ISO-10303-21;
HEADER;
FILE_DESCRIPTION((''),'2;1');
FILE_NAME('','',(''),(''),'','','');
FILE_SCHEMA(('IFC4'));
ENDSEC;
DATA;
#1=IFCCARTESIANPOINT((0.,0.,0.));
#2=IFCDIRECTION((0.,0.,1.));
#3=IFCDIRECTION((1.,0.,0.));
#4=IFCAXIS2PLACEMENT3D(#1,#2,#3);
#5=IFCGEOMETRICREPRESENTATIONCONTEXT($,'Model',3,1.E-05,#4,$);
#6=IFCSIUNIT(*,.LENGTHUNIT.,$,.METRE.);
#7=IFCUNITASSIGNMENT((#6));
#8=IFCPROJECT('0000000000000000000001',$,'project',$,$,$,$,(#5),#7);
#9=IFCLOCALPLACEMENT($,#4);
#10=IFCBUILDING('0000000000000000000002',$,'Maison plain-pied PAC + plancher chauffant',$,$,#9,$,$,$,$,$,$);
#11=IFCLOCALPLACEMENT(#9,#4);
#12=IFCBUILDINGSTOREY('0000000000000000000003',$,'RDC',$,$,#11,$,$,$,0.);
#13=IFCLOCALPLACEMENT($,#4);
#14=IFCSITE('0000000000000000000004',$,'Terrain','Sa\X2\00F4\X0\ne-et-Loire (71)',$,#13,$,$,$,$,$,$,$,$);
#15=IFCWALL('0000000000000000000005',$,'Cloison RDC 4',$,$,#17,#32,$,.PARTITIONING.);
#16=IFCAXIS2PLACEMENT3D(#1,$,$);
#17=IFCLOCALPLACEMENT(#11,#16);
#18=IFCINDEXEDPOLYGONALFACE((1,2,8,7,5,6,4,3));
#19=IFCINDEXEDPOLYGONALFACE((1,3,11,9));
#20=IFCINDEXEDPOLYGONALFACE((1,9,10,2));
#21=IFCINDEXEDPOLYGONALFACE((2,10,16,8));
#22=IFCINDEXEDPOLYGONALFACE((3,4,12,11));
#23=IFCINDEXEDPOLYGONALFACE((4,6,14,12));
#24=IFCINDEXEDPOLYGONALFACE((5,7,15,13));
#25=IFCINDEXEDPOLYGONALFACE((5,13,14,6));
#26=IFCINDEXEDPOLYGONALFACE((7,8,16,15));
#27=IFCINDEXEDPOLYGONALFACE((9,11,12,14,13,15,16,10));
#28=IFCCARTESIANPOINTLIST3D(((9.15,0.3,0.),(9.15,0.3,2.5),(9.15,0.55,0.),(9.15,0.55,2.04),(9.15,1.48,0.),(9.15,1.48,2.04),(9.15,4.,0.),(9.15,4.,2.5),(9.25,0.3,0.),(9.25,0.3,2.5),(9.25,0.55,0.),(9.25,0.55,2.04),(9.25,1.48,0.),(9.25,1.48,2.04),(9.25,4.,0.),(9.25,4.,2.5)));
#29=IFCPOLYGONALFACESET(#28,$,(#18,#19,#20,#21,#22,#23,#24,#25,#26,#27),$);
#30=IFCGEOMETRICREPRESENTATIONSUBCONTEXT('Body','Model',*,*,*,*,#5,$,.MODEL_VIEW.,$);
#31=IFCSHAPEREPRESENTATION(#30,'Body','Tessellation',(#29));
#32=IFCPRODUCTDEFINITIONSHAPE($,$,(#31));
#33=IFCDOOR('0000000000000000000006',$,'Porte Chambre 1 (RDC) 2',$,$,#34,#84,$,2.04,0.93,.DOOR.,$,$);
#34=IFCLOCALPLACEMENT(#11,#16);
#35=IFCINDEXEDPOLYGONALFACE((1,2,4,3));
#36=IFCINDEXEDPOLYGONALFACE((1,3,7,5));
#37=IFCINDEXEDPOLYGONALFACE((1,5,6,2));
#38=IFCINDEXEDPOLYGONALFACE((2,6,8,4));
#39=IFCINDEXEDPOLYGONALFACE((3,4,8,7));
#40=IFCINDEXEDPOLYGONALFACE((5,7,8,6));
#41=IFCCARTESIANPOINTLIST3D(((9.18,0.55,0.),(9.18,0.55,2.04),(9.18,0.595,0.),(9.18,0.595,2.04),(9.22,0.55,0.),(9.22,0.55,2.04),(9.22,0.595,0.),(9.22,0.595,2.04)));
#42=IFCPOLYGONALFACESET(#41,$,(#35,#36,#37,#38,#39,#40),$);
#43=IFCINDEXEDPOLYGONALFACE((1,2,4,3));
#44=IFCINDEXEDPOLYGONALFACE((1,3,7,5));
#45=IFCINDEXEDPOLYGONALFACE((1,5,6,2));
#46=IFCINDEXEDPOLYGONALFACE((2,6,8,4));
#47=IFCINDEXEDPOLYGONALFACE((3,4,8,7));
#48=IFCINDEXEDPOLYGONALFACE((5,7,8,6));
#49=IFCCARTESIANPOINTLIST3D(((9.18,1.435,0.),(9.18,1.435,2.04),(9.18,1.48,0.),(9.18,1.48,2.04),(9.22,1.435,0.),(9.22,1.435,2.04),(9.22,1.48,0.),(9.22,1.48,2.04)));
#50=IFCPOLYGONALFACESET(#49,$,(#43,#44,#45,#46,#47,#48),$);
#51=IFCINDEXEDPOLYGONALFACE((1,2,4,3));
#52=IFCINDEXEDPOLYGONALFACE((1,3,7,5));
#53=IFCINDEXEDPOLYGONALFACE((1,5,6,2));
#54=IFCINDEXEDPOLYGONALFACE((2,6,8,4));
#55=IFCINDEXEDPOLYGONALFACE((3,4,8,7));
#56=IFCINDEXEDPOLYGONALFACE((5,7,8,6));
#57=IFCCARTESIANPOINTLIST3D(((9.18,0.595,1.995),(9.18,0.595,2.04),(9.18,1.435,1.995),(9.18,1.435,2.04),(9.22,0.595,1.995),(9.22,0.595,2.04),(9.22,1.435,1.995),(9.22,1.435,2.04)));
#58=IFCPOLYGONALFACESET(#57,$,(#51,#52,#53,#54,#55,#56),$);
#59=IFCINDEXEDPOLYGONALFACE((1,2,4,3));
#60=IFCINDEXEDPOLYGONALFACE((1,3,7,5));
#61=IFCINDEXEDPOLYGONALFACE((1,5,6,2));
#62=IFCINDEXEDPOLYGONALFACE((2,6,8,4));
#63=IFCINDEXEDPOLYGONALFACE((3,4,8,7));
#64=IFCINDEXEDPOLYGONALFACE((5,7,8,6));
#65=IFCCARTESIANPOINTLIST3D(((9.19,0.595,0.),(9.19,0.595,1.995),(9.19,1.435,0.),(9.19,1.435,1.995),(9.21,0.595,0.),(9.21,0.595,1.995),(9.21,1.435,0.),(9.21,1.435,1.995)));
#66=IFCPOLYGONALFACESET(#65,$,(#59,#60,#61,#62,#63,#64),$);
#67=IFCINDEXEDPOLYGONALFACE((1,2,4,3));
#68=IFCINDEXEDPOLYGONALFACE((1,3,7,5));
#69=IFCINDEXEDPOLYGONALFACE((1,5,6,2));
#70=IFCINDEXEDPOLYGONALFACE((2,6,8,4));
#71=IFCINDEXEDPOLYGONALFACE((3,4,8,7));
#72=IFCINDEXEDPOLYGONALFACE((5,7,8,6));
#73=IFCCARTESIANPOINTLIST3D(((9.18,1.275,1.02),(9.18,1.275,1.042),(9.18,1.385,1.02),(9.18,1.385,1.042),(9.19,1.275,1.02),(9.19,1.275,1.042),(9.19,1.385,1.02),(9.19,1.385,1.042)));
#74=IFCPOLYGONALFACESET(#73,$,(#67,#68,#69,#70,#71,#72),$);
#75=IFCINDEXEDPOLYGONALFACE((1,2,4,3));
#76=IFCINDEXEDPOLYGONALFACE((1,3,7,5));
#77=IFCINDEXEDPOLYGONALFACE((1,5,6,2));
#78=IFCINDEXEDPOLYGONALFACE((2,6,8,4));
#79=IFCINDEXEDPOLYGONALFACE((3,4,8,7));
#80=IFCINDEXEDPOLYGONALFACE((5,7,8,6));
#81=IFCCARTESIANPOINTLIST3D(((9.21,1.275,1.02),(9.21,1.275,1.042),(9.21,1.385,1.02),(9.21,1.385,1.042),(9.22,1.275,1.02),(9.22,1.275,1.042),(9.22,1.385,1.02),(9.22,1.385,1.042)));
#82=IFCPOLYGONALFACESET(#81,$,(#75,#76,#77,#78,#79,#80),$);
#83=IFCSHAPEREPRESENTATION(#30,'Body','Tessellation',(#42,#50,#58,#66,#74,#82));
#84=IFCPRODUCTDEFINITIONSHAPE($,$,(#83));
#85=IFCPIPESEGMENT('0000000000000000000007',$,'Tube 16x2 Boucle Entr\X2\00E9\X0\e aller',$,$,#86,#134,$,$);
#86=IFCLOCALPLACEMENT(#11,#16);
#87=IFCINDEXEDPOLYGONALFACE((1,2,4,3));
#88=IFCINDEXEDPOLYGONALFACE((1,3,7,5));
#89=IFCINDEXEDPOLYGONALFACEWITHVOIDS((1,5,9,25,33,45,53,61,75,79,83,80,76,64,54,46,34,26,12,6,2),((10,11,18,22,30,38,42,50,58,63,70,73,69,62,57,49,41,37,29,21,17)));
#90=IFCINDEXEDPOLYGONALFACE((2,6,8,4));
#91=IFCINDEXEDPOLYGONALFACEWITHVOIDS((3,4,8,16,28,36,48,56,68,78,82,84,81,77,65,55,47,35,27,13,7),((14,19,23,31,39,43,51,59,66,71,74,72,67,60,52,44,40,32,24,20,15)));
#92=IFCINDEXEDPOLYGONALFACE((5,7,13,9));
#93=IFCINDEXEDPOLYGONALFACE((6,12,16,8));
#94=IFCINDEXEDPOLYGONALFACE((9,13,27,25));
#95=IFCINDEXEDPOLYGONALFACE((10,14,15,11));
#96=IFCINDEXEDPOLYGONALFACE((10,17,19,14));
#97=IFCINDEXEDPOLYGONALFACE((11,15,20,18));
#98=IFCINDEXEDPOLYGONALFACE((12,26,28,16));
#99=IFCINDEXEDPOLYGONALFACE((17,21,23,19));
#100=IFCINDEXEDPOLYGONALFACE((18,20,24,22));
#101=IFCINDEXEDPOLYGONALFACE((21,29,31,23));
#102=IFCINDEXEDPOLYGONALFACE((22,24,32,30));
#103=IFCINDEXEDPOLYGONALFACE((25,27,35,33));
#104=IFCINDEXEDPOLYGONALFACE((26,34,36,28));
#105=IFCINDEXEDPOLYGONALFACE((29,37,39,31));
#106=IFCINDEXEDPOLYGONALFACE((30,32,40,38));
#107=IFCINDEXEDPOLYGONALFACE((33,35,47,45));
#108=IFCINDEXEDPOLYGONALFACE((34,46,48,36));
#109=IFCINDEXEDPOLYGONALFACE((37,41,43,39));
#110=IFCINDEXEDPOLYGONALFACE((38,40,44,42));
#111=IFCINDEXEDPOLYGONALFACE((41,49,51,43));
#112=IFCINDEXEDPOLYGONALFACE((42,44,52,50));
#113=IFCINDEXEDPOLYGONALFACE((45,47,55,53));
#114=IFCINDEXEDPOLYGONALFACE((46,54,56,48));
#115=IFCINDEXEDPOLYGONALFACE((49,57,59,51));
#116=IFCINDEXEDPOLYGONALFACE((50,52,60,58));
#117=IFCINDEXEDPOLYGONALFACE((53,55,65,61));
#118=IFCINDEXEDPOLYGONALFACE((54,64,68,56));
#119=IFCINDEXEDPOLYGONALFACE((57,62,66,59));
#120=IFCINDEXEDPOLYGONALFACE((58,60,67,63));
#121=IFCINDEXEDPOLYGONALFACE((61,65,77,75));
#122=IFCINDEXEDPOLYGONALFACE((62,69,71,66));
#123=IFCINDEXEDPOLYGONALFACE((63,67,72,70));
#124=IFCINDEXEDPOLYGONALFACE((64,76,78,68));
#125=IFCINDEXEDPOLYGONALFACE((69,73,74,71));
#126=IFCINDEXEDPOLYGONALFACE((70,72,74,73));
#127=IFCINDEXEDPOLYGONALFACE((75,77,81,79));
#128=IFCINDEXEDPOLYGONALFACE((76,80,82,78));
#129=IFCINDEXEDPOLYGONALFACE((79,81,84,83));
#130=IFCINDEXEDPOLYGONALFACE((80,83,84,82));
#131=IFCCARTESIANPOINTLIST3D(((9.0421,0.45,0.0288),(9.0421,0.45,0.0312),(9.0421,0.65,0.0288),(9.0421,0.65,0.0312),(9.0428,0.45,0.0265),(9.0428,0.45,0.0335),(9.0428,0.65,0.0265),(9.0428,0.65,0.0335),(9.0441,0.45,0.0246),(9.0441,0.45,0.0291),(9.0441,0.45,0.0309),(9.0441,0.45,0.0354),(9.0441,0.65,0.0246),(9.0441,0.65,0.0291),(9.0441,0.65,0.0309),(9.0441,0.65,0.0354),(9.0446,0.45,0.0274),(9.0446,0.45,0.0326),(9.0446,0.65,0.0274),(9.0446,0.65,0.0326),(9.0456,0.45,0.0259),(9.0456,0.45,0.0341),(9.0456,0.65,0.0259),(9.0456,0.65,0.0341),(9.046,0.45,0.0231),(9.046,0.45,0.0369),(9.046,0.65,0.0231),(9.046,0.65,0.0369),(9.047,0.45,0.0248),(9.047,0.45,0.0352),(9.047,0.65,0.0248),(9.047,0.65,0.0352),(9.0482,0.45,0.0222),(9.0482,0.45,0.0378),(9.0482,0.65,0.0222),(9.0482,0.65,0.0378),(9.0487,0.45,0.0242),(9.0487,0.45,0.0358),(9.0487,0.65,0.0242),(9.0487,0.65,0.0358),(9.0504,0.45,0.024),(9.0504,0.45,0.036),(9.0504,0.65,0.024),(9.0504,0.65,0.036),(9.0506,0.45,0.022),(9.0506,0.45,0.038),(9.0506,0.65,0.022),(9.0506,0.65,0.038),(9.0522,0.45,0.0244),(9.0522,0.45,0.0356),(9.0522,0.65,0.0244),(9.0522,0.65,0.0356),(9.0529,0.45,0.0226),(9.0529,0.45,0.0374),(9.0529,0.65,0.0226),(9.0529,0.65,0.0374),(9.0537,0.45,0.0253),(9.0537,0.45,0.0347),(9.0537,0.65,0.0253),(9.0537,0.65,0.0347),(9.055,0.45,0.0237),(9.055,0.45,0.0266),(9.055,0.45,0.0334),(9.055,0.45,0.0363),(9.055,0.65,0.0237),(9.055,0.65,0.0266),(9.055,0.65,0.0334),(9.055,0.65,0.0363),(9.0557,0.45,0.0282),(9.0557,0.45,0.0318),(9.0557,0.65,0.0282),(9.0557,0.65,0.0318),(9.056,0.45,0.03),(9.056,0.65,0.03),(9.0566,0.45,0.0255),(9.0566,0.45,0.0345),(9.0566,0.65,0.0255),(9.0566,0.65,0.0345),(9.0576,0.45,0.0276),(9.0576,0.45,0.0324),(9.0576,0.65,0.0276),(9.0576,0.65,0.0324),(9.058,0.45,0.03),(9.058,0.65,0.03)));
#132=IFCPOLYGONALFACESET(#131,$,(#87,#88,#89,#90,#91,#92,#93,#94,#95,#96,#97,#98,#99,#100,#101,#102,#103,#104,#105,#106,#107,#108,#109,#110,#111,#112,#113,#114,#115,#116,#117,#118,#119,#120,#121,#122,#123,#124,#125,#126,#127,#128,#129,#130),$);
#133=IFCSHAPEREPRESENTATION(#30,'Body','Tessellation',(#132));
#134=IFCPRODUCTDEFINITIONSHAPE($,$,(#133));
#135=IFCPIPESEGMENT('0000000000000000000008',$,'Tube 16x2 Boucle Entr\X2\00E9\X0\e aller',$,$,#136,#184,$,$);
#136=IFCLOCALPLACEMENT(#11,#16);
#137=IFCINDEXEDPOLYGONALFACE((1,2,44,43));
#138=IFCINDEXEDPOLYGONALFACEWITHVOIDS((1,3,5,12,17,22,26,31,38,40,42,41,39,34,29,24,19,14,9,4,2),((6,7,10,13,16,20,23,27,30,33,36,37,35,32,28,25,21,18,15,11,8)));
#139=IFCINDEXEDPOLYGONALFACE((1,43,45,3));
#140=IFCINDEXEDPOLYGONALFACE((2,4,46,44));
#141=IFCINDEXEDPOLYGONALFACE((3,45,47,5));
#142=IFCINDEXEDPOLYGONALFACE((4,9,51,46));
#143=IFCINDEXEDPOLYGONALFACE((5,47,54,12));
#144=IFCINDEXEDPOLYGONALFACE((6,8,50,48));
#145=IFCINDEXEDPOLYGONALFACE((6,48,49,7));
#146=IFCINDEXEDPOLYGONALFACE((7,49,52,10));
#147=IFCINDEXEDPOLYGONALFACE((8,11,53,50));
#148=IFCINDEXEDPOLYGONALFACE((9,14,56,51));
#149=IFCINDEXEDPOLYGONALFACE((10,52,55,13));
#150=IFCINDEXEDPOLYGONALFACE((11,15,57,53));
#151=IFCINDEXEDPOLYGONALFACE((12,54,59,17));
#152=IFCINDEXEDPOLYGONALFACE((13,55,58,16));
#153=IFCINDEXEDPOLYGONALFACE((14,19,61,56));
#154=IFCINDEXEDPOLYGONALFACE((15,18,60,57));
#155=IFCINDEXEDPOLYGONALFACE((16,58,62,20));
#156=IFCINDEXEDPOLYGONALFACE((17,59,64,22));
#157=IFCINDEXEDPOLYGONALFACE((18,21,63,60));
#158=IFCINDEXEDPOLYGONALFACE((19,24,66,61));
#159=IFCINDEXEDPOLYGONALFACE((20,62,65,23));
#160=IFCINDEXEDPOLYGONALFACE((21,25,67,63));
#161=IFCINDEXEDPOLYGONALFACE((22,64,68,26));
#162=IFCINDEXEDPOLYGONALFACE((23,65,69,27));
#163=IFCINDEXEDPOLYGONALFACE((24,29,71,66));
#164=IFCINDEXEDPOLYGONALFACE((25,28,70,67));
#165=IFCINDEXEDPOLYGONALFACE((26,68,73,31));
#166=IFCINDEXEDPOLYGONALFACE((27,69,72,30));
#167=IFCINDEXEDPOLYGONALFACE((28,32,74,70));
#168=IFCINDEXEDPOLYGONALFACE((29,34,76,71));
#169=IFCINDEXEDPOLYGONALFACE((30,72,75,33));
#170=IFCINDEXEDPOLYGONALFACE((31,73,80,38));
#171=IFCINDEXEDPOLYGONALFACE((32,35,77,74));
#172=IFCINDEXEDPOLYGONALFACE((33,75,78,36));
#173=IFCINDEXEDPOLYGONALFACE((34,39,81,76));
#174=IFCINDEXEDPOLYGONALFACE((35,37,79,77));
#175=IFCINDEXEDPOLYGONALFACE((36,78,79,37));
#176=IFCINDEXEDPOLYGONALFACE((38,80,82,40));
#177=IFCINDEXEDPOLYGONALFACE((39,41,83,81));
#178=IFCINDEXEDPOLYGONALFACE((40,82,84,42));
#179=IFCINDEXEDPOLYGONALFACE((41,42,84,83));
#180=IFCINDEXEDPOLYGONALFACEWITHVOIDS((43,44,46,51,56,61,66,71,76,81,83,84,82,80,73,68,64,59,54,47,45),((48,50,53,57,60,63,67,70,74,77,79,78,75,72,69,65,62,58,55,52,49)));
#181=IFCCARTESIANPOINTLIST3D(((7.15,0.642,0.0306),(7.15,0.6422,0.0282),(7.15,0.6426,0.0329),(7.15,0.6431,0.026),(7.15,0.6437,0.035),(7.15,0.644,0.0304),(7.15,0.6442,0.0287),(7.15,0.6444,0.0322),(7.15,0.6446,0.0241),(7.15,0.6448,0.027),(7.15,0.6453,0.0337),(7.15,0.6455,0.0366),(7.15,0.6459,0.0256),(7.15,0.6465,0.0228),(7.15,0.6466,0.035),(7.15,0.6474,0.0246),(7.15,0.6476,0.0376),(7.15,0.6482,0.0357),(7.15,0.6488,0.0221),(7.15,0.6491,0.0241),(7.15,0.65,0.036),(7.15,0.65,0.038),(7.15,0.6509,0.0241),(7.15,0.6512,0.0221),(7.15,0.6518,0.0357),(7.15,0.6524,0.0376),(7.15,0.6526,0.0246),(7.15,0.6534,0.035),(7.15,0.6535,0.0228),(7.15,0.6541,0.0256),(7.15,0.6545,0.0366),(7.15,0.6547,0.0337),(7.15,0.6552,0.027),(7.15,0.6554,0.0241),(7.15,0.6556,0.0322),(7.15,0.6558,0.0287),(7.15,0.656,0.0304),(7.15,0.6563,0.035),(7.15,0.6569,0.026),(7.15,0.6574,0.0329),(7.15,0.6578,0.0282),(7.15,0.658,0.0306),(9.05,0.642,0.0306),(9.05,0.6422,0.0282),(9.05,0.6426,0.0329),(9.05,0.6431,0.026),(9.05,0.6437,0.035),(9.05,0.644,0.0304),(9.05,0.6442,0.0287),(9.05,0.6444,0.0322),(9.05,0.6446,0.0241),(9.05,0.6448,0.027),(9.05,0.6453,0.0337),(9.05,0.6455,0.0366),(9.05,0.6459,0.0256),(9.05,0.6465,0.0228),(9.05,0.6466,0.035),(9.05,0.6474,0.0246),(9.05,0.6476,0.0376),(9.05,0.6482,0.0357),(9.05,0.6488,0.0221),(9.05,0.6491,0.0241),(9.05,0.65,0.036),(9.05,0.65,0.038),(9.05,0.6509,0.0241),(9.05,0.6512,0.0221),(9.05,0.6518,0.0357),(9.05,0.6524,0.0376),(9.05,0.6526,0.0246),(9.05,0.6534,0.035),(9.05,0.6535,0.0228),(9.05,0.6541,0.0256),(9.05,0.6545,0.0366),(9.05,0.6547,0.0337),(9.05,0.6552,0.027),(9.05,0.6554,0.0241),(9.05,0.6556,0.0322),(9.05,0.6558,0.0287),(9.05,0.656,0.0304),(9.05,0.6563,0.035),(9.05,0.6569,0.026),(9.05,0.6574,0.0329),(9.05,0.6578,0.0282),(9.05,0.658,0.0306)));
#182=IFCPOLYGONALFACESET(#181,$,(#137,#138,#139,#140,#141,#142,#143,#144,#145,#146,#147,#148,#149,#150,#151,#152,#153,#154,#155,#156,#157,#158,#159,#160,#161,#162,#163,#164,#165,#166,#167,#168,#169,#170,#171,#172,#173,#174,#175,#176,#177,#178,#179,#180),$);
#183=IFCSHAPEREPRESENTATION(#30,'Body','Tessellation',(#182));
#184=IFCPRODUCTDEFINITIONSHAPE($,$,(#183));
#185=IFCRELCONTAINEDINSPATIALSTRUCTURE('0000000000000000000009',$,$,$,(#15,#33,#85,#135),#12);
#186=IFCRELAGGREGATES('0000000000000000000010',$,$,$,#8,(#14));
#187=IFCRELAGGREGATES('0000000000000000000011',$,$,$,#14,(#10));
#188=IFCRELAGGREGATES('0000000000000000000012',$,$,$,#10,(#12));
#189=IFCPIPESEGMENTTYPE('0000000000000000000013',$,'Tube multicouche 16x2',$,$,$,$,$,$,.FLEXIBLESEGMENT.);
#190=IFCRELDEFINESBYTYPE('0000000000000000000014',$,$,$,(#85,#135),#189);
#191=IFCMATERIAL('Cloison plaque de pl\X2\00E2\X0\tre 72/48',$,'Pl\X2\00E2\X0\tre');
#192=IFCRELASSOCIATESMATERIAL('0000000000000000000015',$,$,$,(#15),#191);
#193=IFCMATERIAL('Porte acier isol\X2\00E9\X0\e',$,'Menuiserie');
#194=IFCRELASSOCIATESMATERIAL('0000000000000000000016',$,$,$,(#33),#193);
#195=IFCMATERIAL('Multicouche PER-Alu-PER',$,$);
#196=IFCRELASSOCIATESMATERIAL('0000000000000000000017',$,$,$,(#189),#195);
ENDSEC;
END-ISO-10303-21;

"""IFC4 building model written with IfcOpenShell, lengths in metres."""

from ifc_helpers import new_model, si_unit, frame, frame_2d, origin_with_axes, place, context, subcontext, project, spatial, rectangle, hollow_circle, extrude, material, type_object, element, fill, save


model = new_model("IFC4")

# Units and contexts
model_context = context("Model", 3, precision=1e-05, world=origin_with_axes())
body_context = subcontext(model_context, "Body", "Model", "MODEL_VIEW")
ifc_project = project(units=[si_unit("LENGTHUNIT", "METRE")], contexts=[model_context])

# Site, building, storey
site_placement = place(None, origin_with_axes())
site = spatial("IfcSite", under=ifc_project, at=site_placement, Name="Terrain", Description="Saône-et-Loire (71)")
building_placement = place(None, origin_with_axes())
building = spatial("IfcBuilding", under=site, at=building_placement, Name="Maison plain-pied PAC + plancher chauffant")
storey_placement = place(building_placement, origin_with_axes())
storey = spatial("IfcBuildingStorey", under=building, at=storey_placement, Name="RDC", Elevation=0.0)

# Wall, opening, door
ifc_material_1 = material(Name="Cloison plaque de plâtre 72/48", Category="Plâtre")
wall_placement = place(storey_placement, frame((9.15, 0.3, 0.0), z_axis=(0.0, 0.0, 1.0), x_axis=(1.0, 0.0, 0.0)))
wall = element("IfcWall", 1, at=wall_placement, inside=storey, material=ifc_material_1, Name="Cloison RDC 4", PredefinedType="PARTITIONING", context=body_context, shape_type="SweptSolid", body=[
    extrude(rectangle(XDim=0.1, YDim=3.7, at=frame_2d((0.05, 1.85))), origin_with_axes(), (0.0, 0.0, 1.0), 2.5),
])
opening_placement = place(storey_placement, frame((9.1, 0.55, 0.0), z_axis=(0.0, 0.0, 1.0), x_axis=(1.0, 0.0, 0.0)))
opening = element("IfcOpeningElement", 2, at=opening_placement, cuts=wall, context=body_context, shape_type="SweptSolid", body=[
    extrude(rectangle(XDim=0.2, YDim=0.93, at=frame_2d((0.1, 0.465))), origin_with_axes(), (0.0, 0.0, 1.0), 2.04),
])
ifc_material_2 = material(Name="Porte acier isolée", Category="Menuiserie")
door_placement = place(storey_placement, frame((9.18, 0.55, 0.0), z_axis=(0.0, 0.0, 1.0), x_axis=(1.0, 0.0, 0.0)))
door = element("IfcDoor", 3, at=door_placement, inside=storey, material=ifc_material_2, Name="Porte Chambre 1 (RDC) 2", OverallHeight=2.04, OverallWidth=0.93, PredefinedType="DOOR", context=body_context, shape_type="SweptSolid", body=[
    extrude(rectangle(XDim=0.04, YDim=0.045, at=frame_2d((0.02, 0.0225))), origin_with_axes(), (0.0, 0.0, 1.0), 2.04),
    extrude(rectangle(XDim=0.04, YDim=0.045, at=frame_2d((0.02, 0.0225))), frame((0.0, 0.885, 0.0), z_axis=(0.0, 0.0, 1.0), x_axis=(1.0, 0.0, 0.0)), (0.0, 0.0, 1.0), 2.04),
    extrude(rectangle(XDim=0.04, YDim=0.84, at=frame_2d((0.02, 0.42))), frame((0.0, 0.045, 1.995), z_axis=(0.0, 0.0, 1.0), x_axis=(1.0, 0.0, 0.0)), (0.0, 0.0, 1.0), 0.045),
    extrude(rectangle(XDim=0.02, YDim=0.84, at=frame_2d((0.01, 0.42))), frame((0.01, 0.045, 0.0), z_axis=(0.0, 0.0, 1.0), x_axis=(1.0, 0.0, 0.0)), (0.0, 0.0, 1.0), 1.995),
    extrude(rectangle(XDim=0.01, YDim=0.11, at=frame_2d((0.005, 0.055))), frame((0.0, 0.725, 1.02), z_axis=(0.0, 0.0, 1.0), x_axis=(1.0, 0.0, 0.0)), (0.0, 0.0, 1.0), 0.022),
    extrude(rectangle(XDim=0.01, YDim=0.11, at=frame_2d((0.005, 0.055))), frame((0.03, 0.725, 1.02), z_axis=(0.0, 0.0, 1.0), x_axis=(1.0, 0.0, 0.0)), (0.0, 0.0, 1.0), 0.022),
])
fill(opening, door)

# Pipe segments
ifc_material_3 = material(Name="Multicouche PER-Alu-PER")
pipe_segment_type = type_object("IfcPipeSegmentType", Name="Tube multicouche 16x2", PredefinedType="FLEXIBLESEGMENT", material=ifc_material_3)
pipe_segment_1_placement = place(storey_placement, frame((9.05, 0.45, 0.03), z_axis=(0.0, 1.0, 0.0), x_axis=(1.0, 0.0, 0.0)))
element("IfcPipeSegment", 4, at=pipe_segment_1_placement, inside=storey, type_object=pipe_segment_type, Name="Tube 16x2 Boucle Entrée aller", context=body_context, shape_type="SweptSolid", body=[
    extrude(hollow_circle(Radius=0.008, WallThickness=0.002), origin_with_axes(), (0.0, 0.0, 1.0), 0.2),
])
pipe_segment_2_placement = place(storey_placement, frame((9.05, 0.65, 0.03), z_axis=(-1.0, 0.0, 0.0), x_axis=(0.0, 0.0, 1.0)))
element("IfcPipeSegment", 5, at=pipe_segment_2_placement, inside=storey, type_object=pipe_segment_type, Name="Tube 16x2 Boucle Entrée aller", context=body_context, shape_type="SweptSolid", body=[
    extrude(hollow_circle(Radius=0.008, WallThickness=0.002), origin_with_axes(), (0.0, 0.0, 1.0), 1.9),
])

save(model, "model.ifc")
